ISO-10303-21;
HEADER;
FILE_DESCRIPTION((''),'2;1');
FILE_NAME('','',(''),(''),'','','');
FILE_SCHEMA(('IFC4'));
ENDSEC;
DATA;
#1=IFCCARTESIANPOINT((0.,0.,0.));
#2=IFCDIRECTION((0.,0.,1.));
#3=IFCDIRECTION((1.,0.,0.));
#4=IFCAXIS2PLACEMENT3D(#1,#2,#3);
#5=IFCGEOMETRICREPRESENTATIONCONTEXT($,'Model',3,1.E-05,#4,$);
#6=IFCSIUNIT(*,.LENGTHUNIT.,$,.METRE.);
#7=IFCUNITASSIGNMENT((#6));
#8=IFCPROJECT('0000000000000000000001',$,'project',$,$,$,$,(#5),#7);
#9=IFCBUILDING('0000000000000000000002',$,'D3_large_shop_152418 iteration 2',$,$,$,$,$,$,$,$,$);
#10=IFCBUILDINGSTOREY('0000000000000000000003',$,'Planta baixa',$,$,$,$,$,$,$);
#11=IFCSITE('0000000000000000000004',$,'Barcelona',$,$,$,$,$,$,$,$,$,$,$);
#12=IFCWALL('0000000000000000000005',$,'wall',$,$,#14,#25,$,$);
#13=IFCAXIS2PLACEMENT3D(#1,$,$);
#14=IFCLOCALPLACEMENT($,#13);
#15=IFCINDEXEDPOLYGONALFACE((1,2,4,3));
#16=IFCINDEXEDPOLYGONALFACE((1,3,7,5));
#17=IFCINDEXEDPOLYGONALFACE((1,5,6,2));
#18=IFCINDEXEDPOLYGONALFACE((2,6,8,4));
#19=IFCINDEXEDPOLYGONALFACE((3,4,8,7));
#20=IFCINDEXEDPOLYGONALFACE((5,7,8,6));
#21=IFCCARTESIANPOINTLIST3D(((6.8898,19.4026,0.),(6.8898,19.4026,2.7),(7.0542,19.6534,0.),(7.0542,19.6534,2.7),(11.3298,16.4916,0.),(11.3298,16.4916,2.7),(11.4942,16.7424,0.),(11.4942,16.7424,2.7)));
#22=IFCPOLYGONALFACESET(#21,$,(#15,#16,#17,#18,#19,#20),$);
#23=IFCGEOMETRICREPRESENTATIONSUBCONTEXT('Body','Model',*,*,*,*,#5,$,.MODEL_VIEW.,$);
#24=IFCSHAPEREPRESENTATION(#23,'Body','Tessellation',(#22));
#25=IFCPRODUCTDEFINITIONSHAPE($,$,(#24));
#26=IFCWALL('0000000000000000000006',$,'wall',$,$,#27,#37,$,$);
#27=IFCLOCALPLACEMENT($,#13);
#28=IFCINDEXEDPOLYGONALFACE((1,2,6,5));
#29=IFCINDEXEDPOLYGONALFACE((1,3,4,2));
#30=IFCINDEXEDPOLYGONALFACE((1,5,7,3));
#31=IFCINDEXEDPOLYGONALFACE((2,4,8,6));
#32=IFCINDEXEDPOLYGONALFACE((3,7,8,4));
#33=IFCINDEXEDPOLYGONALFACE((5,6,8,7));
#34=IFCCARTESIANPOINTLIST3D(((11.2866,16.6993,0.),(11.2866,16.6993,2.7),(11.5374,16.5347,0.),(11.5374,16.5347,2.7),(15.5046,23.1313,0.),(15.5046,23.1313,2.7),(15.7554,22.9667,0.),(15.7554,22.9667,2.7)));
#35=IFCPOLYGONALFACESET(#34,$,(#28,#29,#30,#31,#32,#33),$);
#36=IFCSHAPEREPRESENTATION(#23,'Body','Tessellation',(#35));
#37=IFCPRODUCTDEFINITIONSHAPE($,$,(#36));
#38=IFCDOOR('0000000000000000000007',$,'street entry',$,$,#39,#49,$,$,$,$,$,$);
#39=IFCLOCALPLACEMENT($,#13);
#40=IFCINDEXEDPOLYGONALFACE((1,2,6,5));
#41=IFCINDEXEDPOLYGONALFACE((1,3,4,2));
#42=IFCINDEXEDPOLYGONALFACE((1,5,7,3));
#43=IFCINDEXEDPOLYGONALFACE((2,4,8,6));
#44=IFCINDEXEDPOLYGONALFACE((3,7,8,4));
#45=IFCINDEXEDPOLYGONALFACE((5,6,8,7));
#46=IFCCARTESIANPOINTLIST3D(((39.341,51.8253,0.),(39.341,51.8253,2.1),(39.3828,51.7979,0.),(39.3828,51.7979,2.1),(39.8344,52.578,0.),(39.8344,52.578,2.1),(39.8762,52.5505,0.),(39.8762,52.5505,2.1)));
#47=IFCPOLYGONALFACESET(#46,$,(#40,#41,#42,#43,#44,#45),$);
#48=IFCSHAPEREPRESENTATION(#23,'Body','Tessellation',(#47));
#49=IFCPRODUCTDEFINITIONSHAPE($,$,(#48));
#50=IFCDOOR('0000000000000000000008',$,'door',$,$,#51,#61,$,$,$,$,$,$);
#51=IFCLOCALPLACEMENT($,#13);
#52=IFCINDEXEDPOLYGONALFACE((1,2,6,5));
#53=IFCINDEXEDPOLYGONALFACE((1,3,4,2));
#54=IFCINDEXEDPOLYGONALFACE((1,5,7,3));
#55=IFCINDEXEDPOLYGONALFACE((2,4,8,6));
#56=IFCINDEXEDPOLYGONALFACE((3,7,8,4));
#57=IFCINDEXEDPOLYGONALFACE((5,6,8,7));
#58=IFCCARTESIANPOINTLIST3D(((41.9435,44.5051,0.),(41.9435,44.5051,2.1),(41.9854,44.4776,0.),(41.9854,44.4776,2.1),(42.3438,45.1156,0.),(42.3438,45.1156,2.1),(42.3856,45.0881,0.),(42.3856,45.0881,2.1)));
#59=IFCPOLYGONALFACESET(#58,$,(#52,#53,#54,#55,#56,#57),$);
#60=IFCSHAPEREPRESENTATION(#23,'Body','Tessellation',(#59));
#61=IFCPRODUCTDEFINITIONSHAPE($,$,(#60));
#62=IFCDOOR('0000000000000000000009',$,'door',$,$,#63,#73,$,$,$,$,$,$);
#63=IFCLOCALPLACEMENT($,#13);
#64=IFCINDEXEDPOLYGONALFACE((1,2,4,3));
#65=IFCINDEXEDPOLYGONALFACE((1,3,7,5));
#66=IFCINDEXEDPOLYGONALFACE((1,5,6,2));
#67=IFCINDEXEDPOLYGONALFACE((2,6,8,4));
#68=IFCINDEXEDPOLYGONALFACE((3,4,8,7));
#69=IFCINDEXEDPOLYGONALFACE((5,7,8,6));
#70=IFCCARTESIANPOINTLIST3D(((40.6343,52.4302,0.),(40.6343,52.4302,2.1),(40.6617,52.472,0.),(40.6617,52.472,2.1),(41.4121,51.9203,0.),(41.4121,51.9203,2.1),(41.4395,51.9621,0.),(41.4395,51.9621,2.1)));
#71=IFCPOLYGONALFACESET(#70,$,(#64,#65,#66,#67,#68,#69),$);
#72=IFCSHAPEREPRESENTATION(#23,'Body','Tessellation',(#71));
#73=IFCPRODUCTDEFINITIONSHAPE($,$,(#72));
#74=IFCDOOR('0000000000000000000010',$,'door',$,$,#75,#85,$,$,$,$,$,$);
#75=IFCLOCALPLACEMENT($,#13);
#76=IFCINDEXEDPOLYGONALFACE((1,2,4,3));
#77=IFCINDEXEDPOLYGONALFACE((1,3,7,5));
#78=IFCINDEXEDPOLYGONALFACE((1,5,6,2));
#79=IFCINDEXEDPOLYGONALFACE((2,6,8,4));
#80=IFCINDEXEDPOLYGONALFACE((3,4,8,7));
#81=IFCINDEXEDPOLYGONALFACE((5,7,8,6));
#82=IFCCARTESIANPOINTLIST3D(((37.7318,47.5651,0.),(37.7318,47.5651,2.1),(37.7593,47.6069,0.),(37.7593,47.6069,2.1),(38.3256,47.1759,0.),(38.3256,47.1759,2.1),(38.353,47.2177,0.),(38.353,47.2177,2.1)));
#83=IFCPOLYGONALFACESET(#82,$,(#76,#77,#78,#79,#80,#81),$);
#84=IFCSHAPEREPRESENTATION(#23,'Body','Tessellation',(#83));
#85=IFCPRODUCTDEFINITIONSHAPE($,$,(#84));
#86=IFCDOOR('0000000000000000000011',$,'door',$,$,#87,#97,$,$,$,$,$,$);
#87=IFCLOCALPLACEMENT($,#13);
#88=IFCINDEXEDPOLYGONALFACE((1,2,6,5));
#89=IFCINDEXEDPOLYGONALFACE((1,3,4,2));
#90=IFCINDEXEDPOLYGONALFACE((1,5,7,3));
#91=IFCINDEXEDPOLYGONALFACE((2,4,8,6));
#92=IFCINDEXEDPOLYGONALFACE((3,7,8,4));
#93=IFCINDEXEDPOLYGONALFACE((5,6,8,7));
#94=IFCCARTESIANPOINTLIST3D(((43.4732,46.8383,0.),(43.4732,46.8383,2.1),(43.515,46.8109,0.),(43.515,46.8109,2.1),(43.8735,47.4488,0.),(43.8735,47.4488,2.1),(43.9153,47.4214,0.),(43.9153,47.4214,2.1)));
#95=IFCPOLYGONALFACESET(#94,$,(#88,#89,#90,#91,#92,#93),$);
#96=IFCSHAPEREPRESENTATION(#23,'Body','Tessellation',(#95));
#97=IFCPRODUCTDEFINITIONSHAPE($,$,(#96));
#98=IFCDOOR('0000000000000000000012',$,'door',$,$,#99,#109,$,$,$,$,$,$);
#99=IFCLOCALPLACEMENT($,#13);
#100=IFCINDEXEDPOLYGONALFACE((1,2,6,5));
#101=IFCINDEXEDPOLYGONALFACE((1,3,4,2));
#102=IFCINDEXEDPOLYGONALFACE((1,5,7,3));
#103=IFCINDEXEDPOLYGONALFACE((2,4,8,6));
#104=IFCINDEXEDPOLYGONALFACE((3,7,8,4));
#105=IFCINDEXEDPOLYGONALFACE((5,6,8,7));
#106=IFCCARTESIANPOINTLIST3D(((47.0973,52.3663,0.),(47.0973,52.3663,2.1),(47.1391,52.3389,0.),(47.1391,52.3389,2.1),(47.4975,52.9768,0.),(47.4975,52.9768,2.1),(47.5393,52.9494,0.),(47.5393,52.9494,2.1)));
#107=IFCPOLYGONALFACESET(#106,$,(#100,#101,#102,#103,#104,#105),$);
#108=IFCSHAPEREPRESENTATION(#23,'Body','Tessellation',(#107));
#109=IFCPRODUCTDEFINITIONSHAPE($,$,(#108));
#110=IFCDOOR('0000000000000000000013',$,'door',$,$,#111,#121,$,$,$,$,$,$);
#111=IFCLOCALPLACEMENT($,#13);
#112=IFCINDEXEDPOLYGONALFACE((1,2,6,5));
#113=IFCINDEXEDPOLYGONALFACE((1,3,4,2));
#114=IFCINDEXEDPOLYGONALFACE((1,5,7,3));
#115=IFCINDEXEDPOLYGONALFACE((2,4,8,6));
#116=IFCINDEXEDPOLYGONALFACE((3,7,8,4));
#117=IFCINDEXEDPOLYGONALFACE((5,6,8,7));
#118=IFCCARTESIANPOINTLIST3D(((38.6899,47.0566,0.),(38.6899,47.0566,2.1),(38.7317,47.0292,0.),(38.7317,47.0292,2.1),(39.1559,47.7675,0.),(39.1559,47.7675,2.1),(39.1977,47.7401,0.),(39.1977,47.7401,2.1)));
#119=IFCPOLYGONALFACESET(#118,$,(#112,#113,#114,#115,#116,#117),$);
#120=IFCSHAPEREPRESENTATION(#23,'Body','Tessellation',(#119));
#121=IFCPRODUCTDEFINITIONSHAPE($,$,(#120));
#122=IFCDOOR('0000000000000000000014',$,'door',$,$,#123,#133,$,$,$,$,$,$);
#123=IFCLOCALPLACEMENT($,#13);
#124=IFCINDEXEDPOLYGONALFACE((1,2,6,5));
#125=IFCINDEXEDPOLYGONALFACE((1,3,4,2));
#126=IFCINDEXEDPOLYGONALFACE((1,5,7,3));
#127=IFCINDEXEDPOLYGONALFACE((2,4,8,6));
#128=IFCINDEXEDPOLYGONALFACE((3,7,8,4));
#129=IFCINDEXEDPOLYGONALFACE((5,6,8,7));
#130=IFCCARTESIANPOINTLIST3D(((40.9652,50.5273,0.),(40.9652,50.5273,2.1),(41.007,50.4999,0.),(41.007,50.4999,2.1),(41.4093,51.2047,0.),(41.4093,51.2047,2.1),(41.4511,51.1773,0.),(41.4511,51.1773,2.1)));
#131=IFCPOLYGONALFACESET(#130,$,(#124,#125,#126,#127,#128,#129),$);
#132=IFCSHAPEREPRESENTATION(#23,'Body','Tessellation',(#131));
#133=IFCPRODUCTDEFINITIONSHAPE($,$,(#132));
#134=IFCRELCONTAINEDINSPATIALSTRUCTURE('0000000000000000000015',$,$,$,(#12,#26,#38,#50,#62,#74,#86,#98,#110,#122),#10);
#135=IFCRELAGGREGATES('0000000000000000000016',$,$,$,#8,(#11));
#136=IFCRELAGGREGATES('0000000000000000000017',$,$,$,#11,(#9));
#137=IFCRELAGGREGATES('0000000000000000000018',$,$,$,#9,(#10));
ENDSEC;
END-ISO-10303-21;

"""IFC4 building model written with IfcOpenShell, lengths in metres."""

from ifc_helpers import new_model, si_unit, origin, origin_with_axes, place, context, subcontext, project, spatial, polyline, outline, extrude, element, save


model = new_model("IFC4")

# Units and contexts
model_context = context("Model", 3, precision=1e-05, world=origin_with_axes())
body_context = subcontext(model_context, "Body", "Model", "MODEL_VIEW")
ifc_project = project(units=[si_unit("LENGTHUNIT", "METRE")], contexts=[model_context])

# Site, building, storey
site = spatial("IfcSite", under=ifc_project, Name="Barcelona")
building = spatial("IfcBuilding", under=site, Name="D3_large_shop_152418 iteration 2")
storey = spatial("IfcBuildingStorey", under=building, Name="Planta baixa")

# Walls
wall_1_placement = place(None, origin_with_axes())
element("IfcWall", 1, at=wall_1_placement, inside=storey, Name="wall", context=body_context, shape_type="SweptSolid", body=[
    extrude(outline(polyline([(7.0542, 19.6534), (11.4942, 16.7424), (11.3298, 16.4916), (6.8898, 19.4026), (7.0542, 19.6534)])), origin(), (0.0, 0.0, 1.0), 2.7),
])
wall_2_placement = place(None, origin_with_axes())
element("IfcWall", 2, at=wall_2_placement, inside=storey, Name="wall", context=body_context, shape_type="SweptSolid", body=[
    extrude(outline(polyline([(11.2866, 16.6993), (15.5046, 23.1313), (15.7554, 22.9667), (11.5374, 16.5347), (11.2866, 16.6993)])), origin(), (0.0, 0.0, 1.0), 2.7),
])

# Doors
door_1_placement = place(None, origin_with_axes())
element("IfcDoor", 3, at=door_1_placement, inside=storey, Name="street entry", context=body_context, shape_type="SweptSolid", body=[
    extrude(outline(polyline([(39.8762, 52.5505), (39.3828, 51.7979), (39.341, 51.8253), (39.8344, 52.578), (39.8762, 52.5505)])), origin(), (0.0, 0.0, 1.0), 2.1),
])
door_2_placement = place(None, origin_with_axes())
element("IfcDoor", 4, at=door_2_placement, inside=storey, Name="door", context=body_context, shape_type="SweptSolid", body=[
    extrude(outline(polyline([(41.9435, 44.5051), (42.3438, 45.1156), (42.3856, 45.0881), (41.9854, 44.4776), (41.9435, 44.5051)])), origin(), (0.0, 0.0, 1.0), 2.1),
])
door_3_placement = place(None, origin_with_axes())
element("IfcDoor", 5, at=door_3_placement, inside=storey, Name="door", context=body_context, shape_type="SweptSolid", body=[
    extrude(outline(polyline([(40.6617, 52.472), (41.4395, 51.9621), (41.4121, 51.9203), (40.6343, 52.4302), (40.6617, 52.472)])), origin(), (0.0, 0.0, 1.0), 2.1),
])
door_4_placement = place(None, origin_with_axes())
element("IfcDoor", 6, at=door_4_placement, inside=storey, Name="door", context=body_context, shape_type="SweptSolid", body=[
    extrude(outline(polyline([(37.7593, 47.6069), (38.353, 47.2177), (38.3256, 47.1759), (37.7318, 47.5651), (37.7593, 47.6069)])), origin(), (0.0, 0.0, 1.0), 2.1),
])
door_5_placement = place(None, origin_with_axes())
element("IfcDoor", 7, at=door_5_placement, inside=storey, Name="door", context=body_context, shape_type="SweptSolid", body=[
    extrude(outline(polyline([(43.4732, 46.8383), (43.8735, 47.4488), (43.9153, 47.4214), (43.515, 46.8109), (43.4732, 46.8383)])), origin(), (0.0, 0.0, 1.0), 2.1),
])
door_6_placement = place(None, origin_with_axes())
element("IfcDoor", 8, at=door_6_placement, inside=storey, Name="door", context=body_context, shape_type="SweptSolid", body=[
    extrude(outline(polyline([(47.5393, 52.9494), (47.1391, 52.3389), (47.0973, 52.3663), (47.4975, 52.9768), (47.5393, 52.9494)])), origin(), (0.0, 0.0, 1.0), 2.1),
])
door_7_placement = place(None, origin_with_axes())
element("IfcDoor", 9, at=door_7_placement, inside=storey, Name="door", context=body_context, shape_type="SweptSolid", body=[
    extrude(outline(polyline([(39.1977, 47.7401), (38.7317, 47.0292), (38.6899, 47.0566), (39.1559, 47.7675), (39.1977, 47.7401)])), origin(), (0.0, 0.0, 1.0), 2.1),
])
door_8_placement = place(None, origin_with_axes())
element("IfcDoor", 10, at=door_8_placement, inside=storey, Name="door", context=body_context, shape_type="SweptSolid", body=[
    extrude(outline(polyline([(40.9652, 50.5273), (41.4093, 51.2047), (41.4511, 51.1773), (41.007, 50.4999), (40.9652, 50.5273)])), origin(), (0.0, 0.0, 1.0), 2.1),
])

save(model, "model.ifc")
